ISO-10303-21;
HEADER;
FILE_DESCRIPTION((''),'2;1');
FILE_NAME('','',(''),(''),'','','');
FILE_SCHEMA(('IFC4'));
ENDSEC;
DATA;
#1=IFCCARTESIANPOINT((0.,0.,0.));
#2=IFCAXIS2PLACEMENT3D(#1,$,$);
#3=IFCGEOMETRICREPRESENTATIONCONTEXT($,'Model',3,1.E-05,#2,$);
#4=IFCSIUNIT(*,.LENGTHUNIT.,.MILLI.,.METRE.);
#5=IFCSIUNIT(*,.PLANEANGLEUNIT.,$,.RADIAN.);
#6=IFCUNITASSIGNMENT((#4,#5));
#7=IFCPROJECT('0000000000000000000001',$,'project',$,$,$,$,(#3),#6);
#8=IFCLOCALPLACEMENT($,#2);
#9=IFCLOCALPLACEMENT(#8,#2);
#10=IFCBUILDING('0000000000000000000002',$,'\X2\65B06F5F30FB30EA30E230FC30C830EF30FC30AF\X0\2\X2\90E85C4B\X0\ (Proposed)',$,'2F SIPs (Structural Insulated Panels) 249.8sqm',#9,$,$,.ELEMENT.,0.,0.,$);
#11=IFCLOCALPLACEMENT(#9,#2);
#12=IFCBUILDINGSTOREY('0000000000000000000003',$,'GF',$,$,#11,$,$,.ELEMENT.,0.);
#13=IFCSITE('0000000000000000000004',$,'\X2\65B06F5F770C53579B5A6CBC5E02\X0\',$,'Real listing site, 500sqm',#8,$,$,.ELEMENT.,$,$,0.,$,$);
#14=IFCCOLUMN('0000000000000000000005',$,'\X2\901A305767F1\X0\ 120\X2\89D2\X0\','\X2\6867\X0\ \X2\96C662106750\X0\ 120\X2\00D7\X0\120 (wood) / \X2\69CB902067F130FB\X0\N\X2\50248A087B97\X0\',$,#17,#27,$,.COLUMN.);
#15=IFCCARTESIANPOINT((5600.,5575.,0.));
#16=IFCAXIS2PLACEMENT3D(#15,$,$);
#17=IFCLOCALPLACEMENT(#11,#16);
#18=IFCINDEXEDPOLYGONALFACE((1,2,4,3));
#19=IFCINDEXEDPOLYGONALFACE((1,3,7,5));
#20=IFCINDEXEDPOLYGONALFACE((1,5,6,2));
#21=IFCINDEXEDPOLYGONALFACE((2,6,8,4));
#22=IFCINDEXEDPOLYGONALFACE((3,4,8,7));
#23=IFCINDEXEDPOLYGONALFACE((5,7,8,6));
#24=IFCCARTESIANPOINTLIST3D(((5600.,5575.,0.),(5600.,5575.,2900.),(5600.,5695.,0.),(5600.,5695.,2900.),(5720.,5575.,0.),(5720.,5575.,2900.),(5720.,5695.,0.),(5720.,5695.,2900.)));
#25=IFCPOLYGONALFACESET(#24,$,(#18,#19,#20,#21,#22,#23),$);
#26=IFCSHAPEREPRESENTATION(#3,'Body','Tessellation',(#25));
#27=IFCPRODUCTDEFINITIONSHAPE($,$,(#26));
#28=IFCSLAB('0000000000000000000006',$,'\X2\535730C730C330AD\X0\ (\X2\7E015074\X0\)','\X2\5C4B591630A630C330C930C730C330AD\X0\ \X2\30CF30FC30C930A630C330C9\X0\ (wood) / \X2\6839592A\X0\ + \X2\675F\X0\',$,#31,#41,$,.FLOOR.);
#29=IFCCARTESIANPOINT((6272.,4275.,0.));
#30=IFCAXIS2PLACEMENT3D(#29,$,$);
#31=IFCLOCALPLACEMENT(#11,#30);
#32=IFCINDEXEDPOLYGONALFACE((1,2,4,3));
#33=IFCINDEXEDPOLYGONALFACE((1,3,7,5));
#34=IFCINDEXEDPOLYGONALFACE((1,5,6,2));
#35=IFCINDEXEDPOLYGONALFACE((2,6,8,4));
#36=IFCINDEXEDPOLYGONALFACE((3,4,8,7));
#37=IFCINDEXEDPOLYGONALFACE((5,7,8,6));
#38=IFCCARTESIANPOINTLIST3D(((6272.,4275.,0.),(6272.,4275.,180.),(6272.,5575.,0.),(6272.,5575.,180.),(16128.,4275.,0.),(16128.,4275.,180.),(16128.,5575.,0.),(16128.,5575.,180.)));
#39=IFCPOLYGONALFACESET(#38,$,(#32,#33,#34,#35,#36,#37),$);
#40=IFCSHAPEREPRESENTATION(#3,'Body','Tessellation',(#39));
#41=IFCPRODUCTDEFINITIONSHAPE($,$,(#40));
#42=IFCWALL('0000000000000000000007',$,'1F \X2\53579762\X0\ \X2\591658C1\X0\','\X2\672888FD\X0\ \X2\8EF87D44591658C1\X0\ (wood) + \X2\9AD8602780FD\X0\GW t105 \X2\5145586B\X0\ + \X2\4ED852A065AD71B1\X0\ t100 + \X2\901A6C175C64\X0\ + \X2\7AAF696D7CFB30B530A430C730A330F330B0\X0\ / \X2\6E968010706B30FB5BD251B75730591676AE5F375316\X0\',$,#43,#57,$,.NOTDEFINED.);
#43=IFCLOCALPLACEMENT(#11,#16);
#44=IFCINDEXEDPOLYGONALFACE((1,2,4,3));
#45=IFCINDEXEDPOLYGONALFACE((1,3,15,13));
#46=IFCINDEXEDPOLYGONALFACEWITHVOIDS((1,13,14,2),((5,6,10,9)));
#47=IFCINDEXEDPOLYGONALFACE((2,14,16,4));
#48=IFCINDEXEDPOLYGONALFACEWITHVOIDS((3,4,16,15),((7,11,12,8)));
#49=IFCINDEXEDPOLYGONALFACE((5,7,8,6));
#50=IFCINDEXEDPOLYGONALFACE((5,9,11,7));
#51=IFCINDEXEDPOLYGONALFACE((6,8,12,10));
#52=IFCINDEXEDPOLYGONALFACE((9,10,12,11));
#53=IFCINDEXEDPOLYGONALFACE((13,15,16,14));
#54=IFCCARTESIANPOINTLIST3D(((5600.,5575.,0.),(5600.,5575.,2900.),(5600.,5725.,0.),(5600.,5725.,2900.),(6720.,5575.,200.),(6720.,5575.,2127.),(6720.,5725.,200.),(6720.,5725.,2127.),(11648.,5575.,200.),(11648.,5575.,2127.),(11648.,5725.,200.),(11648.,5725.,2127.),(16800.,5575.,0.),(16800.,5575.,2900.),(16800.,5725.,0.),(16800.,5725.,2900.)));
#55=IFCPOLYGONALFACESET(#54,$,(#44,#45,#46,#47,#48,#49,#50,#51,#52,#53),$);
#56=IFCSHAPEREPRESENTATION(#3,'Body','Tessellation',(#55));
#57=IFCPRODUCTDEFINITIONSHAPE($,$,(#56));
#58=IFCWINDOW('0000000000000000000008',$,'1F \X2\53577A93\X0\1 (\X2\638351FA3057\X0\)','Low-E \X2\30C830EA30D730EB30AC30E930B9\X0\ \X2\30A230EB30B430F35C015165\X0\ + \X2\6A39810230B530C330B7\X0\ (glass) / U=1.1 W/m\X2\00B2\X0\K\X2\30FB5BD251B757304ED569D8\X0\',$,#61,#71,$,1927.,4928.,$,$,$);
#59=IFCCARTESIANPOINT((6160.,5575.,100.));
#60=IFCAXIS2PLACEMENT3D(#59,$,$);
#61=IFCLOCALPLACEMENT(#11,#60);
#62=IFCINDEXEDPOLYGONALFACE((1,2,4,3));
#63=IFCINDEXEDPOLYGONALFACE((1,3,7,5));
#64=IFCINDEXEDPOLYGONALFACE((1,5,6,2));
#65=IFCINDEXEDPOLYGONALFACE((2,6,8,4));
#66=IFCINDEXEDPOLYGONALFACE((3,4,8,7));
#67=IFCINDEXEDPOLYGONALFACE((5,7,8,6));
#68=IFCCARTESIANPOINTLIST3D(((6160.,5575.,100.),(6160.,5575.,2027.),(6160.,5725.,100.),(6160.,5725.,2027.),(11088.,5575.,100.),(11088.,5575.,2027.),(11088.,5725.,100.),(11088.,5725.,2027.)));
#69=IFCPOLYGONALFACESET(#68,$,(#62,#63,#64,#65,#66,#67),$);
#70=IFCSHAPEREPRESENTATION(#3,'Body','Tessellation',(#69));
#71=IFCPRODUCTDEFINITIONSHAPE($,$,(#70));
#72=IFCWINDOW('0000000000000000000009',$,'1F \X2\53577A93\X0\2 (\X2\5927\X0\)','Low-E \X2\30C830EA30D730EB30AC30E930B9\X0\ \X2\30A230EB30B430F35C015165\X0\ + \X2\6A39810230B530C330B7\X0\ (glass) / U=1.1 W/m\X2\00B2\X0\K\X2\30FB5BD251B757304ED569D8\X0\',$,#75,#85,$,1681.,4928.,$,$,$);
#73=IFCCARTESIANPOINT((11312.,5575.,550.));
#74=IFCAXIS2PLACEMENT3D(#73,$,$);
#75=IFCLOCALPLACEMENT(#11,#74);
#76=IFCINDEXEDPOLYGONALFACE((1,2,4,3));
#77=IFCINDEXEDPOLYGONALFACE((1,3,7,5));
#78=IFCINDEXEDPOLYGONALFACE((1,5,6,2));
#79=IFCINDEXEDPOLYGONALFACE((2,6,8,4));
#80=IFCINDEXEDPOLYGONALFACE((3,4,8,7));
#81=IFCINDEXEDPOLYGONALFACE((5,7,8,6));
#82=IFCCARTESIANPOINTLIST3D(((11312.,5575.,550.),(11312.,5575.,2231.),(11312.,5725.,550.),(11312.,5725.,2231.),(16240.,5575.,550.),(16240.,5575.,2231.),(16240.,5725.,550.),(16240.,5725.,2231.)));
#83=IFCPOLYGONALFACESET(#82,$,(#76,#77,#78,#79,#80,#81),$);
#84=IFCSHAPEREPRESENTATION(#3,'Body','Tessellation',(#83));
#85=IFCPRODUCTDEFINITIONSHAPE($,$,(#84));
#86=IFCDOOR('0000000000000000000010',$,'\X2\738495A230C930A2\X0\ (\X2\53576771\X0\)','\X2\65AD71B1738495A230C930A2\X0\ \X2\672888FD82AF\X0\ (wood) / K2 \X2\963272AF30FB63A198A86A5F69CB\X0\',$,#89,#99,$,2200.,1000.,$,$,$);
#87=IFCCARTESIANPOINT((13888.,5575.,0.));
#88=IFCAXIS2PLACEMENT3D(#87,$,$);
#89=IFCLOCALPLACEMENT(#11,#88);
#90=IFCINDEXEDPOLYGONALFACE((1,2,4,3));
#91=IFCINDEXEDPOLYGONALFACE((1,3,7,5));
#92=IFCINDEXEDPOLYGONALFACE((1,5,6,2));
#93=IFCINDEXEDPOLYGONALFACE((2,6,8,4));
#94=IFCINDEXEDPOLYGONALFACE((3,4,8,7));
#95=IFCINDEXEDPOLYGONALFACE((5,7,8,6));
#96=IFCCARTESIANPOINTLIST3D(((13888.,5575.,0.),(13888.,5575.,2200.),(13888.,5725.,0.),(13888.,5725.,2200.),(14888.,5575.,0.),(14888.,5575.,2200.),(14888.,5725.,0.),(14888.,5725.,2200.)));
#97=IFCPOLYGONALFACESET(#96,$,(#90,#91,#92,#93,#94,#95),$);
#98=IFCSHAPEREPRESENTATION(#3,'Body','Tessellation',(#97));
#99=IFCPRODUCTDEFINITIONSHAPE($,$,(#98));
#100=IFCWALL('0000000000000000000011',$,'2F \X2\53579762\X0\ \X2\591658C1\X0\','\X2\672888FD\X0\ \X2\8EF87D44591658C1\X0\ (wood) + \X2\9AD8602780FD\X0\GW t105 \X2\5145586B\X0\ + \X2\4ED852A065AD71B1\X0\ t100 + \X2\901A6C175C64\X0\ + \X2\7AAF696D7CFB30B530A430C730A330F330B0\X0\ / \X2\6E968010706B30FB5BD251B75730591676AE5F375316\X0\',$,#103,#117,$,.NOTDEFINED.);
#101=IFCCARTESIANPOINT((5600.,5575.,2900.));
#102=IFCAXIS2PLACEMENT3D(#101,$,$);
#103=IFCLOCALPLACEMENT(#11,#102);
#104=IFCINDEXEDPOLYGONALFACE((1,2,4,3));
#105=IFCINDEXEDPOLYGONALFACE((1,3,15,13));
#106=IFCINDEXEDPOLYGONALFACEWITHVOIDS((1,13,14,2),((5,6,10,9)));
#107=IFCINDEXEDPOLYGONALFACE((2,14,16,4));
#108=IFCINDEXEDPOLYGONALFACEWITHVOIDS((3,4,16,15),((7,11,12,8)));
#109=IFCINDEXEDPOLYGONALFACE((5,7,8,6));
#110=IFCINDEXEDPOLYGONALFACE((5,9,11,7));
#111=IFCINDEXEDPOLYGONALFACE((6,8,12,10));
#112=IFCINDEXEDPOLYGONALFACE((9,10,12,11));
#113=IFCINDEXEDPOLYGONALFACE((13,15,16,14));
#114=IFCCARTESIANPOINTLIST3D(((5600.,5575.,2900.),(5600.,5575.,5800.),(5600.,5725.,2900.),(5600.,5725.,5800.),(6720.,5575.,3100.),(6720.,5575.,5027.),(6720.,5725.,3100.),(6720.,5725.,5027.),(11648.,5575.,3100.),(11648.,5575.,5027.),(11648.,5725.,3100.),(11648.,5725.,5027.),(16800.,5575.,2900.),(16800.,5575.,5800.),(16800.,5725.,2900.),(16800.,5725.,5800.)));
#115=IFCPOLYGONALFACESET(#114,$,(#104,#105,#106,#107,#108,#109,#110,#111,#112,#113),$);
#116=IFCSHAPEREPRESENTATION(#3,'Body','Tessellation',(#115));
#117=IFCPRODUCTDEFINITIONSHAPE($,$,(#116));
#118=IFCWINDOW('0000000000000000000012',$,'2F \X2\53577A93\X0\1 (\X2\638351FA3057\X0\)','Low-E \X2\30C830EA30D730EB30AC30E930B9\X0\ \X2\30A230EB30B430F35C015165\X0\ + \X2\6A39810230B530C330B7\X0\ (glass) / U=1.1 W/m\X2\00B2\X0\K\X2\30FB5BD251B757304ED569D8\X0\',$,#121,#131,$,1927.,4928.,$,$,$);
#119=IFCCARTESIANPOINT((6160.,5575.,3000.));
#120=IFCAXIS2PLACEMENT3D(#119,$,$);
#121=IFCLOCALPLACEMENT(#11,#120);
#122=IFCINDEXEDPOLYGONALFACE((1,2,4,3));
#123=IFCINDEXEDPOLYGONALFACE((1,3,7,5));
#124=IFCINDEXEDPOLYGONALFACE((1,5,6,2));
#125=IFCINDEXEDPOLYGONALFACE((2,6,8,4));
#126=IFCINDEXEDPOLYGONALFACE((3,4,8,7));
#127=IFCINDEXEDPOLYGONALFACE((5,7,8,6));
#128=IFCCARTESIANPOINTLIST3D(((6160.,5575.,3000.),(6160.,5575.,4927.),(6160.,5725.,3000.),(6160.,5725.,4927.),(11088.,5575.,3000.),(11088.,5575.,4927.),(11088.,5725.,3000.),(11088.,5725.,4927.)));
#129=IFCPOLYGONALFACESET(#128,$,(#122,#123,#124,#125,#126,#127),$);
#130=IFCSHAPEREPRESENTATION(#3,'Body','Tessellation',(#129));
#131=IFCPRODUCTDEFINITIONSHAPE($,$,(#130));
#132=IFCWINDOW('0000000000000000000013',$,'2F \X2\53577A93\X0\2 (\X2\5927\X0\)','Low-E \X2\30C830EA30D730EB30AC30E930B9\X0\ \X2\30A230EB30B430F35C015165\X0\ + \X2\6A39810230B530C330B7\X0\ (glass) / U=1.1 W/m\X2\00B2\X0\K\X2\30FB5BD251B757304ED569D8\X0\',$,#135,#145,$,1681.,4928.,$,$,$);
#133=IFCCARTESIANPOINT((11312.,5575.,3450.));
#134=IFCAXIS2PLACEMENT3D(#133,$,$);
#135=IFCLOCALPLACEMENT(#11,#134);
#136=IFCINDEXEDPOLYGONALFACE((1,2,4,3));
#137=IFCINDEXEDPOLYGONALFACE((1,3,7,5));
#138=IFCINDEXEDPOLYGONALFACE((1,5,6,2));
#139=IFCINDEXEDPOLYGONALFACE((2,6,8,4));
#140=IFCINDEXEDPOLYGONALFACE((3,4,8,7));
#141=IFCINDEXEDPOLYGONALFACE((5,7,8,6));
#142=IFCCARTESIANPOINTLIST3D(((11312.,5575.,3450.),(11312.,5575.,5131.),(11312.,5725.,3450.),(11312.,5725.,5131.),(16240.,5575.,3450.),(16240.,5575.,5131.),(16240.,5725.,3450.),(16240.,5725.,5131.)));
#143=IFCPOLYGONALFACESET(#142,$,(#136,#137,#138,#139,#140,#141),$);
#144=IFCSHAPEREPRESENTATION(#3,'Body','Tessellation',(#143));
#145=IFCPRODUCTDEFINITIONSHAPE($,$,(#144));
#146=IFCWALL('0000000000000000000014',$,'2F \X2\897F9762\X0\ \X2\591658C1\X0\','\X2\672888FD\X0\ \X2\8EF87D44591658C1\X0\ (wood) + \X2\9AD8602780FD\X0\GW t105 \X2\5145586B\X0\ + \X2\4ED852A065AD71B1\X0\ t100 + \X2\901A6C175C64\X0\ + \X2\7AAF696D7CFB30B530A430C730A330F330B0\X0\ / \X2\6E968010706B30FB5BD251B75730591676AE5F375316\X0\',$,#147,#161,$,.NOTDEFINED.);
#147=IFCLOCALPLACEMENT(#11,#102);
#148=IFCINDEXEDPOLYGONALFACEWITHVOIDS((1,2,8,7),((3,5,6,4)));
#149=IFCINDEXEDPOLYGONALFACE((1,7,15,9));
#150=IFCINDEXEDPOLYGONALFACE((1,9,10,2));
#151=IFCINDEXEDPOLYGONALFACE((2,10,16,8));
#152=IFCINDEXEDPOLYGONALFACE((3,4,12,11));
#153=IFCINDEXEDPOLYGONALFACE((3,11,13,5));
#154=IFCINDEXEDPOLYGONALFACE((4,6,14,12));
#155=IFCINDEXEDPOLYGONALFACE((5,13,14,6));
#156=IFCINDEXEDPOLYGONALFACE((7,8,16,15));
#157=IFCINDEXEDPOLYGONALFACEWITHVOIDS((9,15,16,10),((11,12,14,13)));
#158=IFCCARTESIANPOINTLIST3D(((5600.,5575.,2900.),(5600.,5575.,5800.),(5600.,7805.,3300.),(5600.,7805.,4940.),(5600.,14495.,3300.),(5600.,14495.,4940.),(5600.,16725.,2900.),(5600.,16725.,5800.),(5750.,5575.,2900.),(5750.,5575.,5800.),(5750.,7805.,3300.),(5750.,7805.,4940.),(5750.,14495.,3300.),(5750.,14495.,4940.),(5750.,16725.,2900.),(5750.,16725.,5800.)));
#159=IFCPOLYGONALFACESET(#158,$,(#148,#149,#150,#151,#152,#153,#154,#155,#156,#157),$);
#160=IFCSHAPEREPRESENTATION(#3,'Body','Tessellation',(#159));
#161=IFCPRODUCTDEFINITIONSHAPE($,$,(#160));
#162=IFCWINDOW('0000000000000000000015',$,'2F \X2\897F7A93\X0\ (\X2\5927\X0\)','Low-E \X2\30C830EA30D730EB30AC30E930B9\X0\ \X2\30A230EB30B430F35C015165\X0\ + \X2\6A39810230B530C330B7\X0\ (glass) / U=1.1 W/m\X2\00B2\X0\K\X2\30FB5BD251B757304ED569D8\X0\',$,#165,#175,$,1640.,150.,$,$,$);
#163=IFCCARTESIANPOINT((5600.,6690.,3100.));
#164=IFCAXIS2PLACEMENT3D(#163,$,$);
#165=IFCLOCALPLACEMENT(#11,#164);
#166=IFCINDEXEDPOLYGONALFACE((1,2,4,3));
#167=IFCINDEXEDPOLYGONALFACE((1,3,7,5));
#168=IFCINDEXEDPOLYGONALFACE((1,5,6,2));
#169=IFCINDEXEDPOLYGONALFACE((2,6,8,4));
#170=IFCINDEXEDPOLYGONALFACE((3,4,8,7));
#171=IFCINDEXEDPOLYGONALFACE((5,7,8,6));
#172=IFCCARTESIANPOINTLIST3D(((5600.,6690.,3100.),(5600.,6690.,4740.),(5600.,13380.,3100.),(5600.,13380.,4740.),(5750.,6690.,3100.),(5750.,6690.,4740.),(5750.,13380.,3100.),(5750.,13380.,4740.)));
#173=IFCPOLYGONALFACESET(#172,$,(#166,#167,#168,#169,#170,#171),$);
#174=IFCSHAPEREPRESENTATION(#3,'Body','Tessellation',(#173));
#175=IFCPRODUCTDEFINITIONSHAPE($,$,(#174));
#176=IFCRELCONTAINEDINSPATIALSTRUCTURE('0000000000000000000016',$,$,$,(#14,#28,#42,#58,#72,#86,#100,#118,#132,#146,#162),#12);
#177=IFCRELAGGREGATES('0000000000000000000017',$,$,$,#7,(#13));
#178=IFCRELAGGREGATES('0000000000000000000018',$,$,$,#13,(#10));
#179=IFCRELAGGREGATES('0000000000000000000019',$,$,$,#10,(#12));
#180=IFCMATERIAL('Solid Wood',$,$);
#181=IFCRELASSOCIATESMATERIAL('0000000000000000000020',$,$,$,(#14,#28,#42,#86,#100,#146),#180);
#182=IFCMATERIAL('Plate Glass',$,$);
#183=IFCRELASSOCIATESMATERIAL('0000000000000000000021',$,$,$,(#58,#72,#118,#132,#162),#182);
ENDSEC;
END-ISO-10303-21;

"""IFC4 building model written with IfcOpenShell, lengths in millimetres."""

from ifc_helpers import new_model, si_unit, frame, frame_2d, origin, place, context, project, spatial, rectangle, extrude, material, element, fill, save


model = new_model("IFC4")

# Units and contexts
model_context = context("Model", 3, precision=1e-05, world=origin())
ifc_project = project(units=[si_unit("LENGTHUNIT", "METRE", prefix="MILLI"), si_unit("PLANEANGLEUNIT", "RADIAN")], contexts=[model_context])

# Site, building, storey
site_placement = place(None, origin())
site = spatial("IfcSite", under=ifc_project, at=site_placement, Name="新潟県南魚沼市", ObjectType="Real listing site, 500sqm", CompositionType="ELEMENT", RefElevation=0.0)
building_placement = place(site_placement, origin())
building = spatial("IfcBuilding", under=site, at=building_placement, Name="新潟・リモートワーク2部屋 (Proposed)", ObjectType="2F SIPs (Structural Insulated Panels) 249.8sqm", CompositionType="ELEMENT", ElevationOfRefHeight=0.0, ElevationOfTerrain=0.0)
storey_placement = place(building_placement, origin())
storey = spatial("IfcBuildingStorey", under=building, at=storey_placement, Name="GF", CompositionType="ELEMENT", Elevation=0.0)

# Column
ifc_material_1 = material(Name="Solid Wood")
column_placement = place(storey_placement, frame((5600.0, 5575.0, 0.0)))
element("IfcColumn", 1, at=column_placement, inside=storey, material=ifc_material_1, Name="通し柱 120角", Description="桧 集成材 120×120 (wood) / 構造柱・N値計算", PredefinedType="COLUMN", context=model_context, shape_type="SweptSolid", body=[
    extrude(rectangle(XDim=120.0, YDim=120.0, at=frame_2d((60.0, 60.0))), frame((5600.0, 5575.0, 0.0)), (0.0, 0.0, 1.0), 2900.0),
])

# Slab
slab_1_placement = place(storey_placement, frame((6272.0, 4275.0, 0.0)))
element("IfcSlab", 2, at=slab_1_placement, inside=storey, material=ifc_material_1, Name="南デッキ (縁側)", Description="屋外ウッドデッキ ハードウッド (wood) / 根太 + 束", PredefinedType="FLOOR", context=model_context, shape_type="SweptSolid", body=[
    extrude(rectangle(XDim=9856.0, YDim=1300.0, at=frame_2d((4928.0, 650.0))), frame((6272.0, 4275.0, 0.0)), (0.0, 0.0, 1.0), 180.0),
])

# Wall, openings, windows, door
wall_1_placement = place(storey_placement, frame((5600.0, 5575.0, 0.0)))
wall_1 = element("IfcWall", 3, at=wall_1_placement, inside=storey, material=ifc_material_1, Name="1F 南面 外壁", Description="木製 軸組外壁 (wood) + 高性能GW t105 充填 + 付加断熱 t100 + 通気層 + 窯業系サイディング / 準耐火・寒冷地外皮強化", PredefinedType="NOTDEFINED", context=model_context, shape_type="SweptSolid", body=[
    extrude(rectangle(XDim=11200.0, YDim=150.0, at=frame_2d((5600.0, 75.0))), frame((5600.0, 5575.0, 0.0)), (0.0, 0.0, 1.0), 2900.0),
])
opening_1_placement = place(storey_placement, frame((6160.0, 5575.0, 100.0)))
opening_1 = element("IfcOpeningElement", 4, at=opening_1_placement, cuts=wall_1, PredefinedType="NOTDEFINED", context=model_context, shape_type="SweptSolid", body=[
    extrude(rectangle(XDim=4928.0, YDim=150.0, at=frame_2d((2464.0, 75.0))), frame((6160.0, 5575.0, 100.0)), (0.0, 0.0, 1.0), 1927.0),
])
opening_2_placement = place(storey_placement, frame((11312.0, 5575.0, 550.0)))
opening_2 = element("IfcOpeningElement", 5, at=opening_2_placement, cuts=wall_1, PredefinedType="NOTDEFINED", context=model_context, shape_type="SweptSolid", body=[
    extrude(rectangle(XDim=4928.0, YDim=150.0, at=frame_2d((2464.0, 75.0))), frame((11312.0, 5575.0, 550.0)), (0.0, 0.0, 1.0), 1681.0),
])
opening_3_placement = place(storey_placement, frame((13888.0, 5575.0, 0.0)))
opening_3 = element("IfcOpeningElement", 6, at=opening_3_placement, cuts=wall_1, PredefinedType="NOTDEFINED", context=model_context, shape_type="SweptSolid", body=[
    extrude(rectangle(XDim=1000.0, YDim=150.0, at=frame_2d((500.0, 75.0))), frame((13888.0, 5575.0, 0.0)), (0.0, 0.0, 1.0), 2200.0),
])
ifc_material_2 = material(Name="Plate Glass")
window_1_placement = place(storey_placement, frame((6160.0, 5575.0, 100.0)))
window_1 = element("IfcWindow", 7, at=window_1_placement, inside=storey, material=ifc_material_2, Name="1F 南窓1 (掃出し)", Description="Low-E トリプルガラス アルゴン封入 + 樹脂サッシ (glass) / U=1.1 W/m²K・寒冷地仕様", OverallHeight=1927.0, OverallWidth=4928.0, context=model_context, shape_type="SweptSolid", body=[
    extrude(rectangle(XDim=4928.0, YDim=150.0, at=frame_2d((2464.0, 75.0))), frame((6160.0, 5575.0, 100.0)), (0.0, 0.0, 1.0), 1927.0),
])
fill(opening_1, window_1)
window_2_placement = place(storey_placement, frame((11312.0, 5575.0, 550.0)))
window_2 = element("IfcWindow", 8, at=window_2_placement, inside=storey, material=ifc_material_2, Name="1F 南窓2 (大)", Description="Low-E トリプルガラス アルゴン封入 + 樹脂サッシ (glass) / U=1.1 W/m²K・寒冷地仕様", OverallHeight=1681.0, OverallWidth=4928.0, context=model_context, shape_type="SweptSolid", body=[
    extrude(rectangle(XDim=4928.0, YDim=150.0, at=frame_2d((2464.0, 75.0))), frame((11312.0, 5575.0, 550.0)), (0.0, 0.0, 1.0), 1681.0),
])
fill(opening_2, window_2)
door_placement = place(storey_placement, frame((13888.0, 5575.0, 0.0)))
door = element("IfcDoor", 9, at=door_placement, inside=storey, material=ifc_material_1, Name="玄関ドア (南東)", Description="断熱玄関ドア 木製芯 (wood) / K2 防犯・採風機構", OverallHeight=2200.0, OverallWidth=1000.0, context=model_context, shape_type="SweptSolid", body=[
    extrude(rectangle(XDim=1000.0, YDim=150.0, at=frame_2d((500.0, 75.0))), frame((13888.0, 5575.0, 0.0)), (0.0, 0.0, 1.0), 2200.0),
])
fill(opening_3, door)

# Wall, openings, windows
wall_2_placement = place(storey_placement, frame((5600.0, 5575.0, 2900.0)))
wall_2 = element("IfcWall", 10, at=wall_2_placement, inside=storey, material=ifc_material_1, Name="2F 南面 外壁", Description="木製 軸組外壁 (wood) + 高性能GW t105 充填 + 付加断熱 t100 + 通気層 + 窯業系サイディング / 準耐火・寒冷地外皮強化", PredefinedType="NOTDEFINED", context=model_context, shape_type="SweptSolid", body=[
    extrude(rectangle(XDim=11200.0, YDim=150.0, at=frame_2d((5600.0, 75.0))), frame((5600.0, 5575.0, 2900.0)), (0.0, 0.0, 1.0), 2900.0),
])
opening_4_placement = place(storey_placement, frame((6160.0, 5575.0, 3000.0)))
opening_4 = element("IfcOpeningElement", 11, at=opening_4_placement, cuts=wall_2, PredefinedType="NOTDEFINED", context=model_context, shape_type="SweptSolid", body=[
    extrude(rectangle(XDim=4928.0, YDim=150.0, at=frame_2d((2464.0, 75.0))), frame((6160.0, 5575.0, 3000.0)), (0.0, 0.0, 1.0), 1927.0),
])
opening_5_placement = place(storey_placement, frame((11312.0, 5575.0, 3450.0)))
opening_5 = element("IfcOpeningElement", 12, at=opening_5_placement, cuts=wall_2, PredefinedType="NOTDEFINED", context=model_context, shape_type="SweptSolid", body=[
    extrude(rectangle(XDim=4928.0, YDim=150.0, at=frame_2d((2464.0, 75.0))), frame((11312.0, 5575.0, 3450.0)), (0.0, 0.0, 1.0), 1681.0),
])
window_3_placement = place(storey_placement, frame((6160.0, 5575.0, 3000.0)))
window_3 = element("IfcWindow", 13, at=window_3_placement, inside=storey, material=ifc_material_2, Name="2F 南窓1 (掃出し)", Description="Low-E トリプルガラス アルゴン封入 + 樹脂サッシ (glass) / U=1.1 W/m²K・寒冷地仕様", OverallHeight=1927.0, OverallWidth=4928.0, context=model_context, shape_type="SweptSolid", body=[
    extrude(rectangle(XDim=4928.0, YDim=150.0, at=frame_2d((2464.0, 75.0))), frame((6160.0, 5575.0, 3000.0)), (0.0, 0.0, 1.0), 1927.0),
])
fill(opening_4, window_3)
window_4_placement = place(storey_placement, frame((11312.0, 5575.0, 3450.0)))
window_4 = element("IfcWindow", 14, at=window_4_placement, inside=storey, material=ifc_material_2, Name="2F 南窓2 (大)", Description="Low-E トリプルガラス アルゴン封入 + 樹脂サッシ (glass) / U=1.1 W/m²K・寒冷地仕様", OverallHeight=1681.0, OverallWidth=4928.0, context=model_context, shape_type="SweptSolid", body=[
    extrude(rectangle(XDim=4928.0, YDim=150.0, at=frame_2d((2464.0, 75.0))), frame((11312.0, 5575.0, 3450.0)), (0.0, 0.0, 1.0), 1681.0),
])
fill(opening_5, window_4)

# Wall, opening, window
wall_3_placement = place(storey_placement, frame((5600.0, 5575.0, 2900.0)))
wall_3 = element("IfcWall", 15, at=wall_3_placement, inside=storey, material=ifc_material_1, Name="2F 西面 外壁", Description="木製 軸組外壁 (wood) + 高性能GW t105 充填 + 付加断熱 t100 + 通気層 + 窯業系サイディング / 準耐火・寒冷地外皮強化", PredefinedType="NOTDEFINED", context=model_context, shape_type="SweptSolid", body=[
    extrude(rectangle(XDim=150.0, YDim=11150.0, at=frame_2d((75.0, 5575.0))), frame((5600.0, 5575.0, 2900.0)), (0.0, 0.0, 1.0), 2900.0),
])
opening_6_placement = place(storey_placement, frame((5600.0, 6690.0, 3100.0)))
opening_6 = element("IfcOpeningElement", 16, at=opening_6_placement, cuts=wall_3, PredefinedType="NOTDEFINED", context=model_context, shape_type="SweptSolid", body=[
    extrude(rectangle(XDim=150.0, YDim=6690.0, at=frame_2d((75.0, 3345.0))), frame((5600.0, 6690.0, 3100.0)), (0.0, 0.0, 1.0), 1640.0),
])
window_5_placement = place(storey_placement, frame((5600.0, 6690.0, 3100.0)))
window_5 = element("IfcWindow", 17, at=window_5_placement, inside=storey, material=ifc_material_2, Name="2F 西窓 (大)", Description="Low-E トリプルガラス アルゴン封入 + 樹脂サッシ (glass) / U=1.1 W/m²K・寒冷地仕様", OverallHeight=1640.0, OverallWidth=150.0, context=model_context, shape_type="SweptSolid", body=[
    extrude(rectangle(XDim=150.0, YDim=6690.0, at=frame_2d((75.0, 3345.0))), frame((5600.0, 6690.0, 3100.0)), (0.0, 0.0, 1.0), 1640.0),
])
fill(opening_6, window_5)

save(model, "model.ifc")
